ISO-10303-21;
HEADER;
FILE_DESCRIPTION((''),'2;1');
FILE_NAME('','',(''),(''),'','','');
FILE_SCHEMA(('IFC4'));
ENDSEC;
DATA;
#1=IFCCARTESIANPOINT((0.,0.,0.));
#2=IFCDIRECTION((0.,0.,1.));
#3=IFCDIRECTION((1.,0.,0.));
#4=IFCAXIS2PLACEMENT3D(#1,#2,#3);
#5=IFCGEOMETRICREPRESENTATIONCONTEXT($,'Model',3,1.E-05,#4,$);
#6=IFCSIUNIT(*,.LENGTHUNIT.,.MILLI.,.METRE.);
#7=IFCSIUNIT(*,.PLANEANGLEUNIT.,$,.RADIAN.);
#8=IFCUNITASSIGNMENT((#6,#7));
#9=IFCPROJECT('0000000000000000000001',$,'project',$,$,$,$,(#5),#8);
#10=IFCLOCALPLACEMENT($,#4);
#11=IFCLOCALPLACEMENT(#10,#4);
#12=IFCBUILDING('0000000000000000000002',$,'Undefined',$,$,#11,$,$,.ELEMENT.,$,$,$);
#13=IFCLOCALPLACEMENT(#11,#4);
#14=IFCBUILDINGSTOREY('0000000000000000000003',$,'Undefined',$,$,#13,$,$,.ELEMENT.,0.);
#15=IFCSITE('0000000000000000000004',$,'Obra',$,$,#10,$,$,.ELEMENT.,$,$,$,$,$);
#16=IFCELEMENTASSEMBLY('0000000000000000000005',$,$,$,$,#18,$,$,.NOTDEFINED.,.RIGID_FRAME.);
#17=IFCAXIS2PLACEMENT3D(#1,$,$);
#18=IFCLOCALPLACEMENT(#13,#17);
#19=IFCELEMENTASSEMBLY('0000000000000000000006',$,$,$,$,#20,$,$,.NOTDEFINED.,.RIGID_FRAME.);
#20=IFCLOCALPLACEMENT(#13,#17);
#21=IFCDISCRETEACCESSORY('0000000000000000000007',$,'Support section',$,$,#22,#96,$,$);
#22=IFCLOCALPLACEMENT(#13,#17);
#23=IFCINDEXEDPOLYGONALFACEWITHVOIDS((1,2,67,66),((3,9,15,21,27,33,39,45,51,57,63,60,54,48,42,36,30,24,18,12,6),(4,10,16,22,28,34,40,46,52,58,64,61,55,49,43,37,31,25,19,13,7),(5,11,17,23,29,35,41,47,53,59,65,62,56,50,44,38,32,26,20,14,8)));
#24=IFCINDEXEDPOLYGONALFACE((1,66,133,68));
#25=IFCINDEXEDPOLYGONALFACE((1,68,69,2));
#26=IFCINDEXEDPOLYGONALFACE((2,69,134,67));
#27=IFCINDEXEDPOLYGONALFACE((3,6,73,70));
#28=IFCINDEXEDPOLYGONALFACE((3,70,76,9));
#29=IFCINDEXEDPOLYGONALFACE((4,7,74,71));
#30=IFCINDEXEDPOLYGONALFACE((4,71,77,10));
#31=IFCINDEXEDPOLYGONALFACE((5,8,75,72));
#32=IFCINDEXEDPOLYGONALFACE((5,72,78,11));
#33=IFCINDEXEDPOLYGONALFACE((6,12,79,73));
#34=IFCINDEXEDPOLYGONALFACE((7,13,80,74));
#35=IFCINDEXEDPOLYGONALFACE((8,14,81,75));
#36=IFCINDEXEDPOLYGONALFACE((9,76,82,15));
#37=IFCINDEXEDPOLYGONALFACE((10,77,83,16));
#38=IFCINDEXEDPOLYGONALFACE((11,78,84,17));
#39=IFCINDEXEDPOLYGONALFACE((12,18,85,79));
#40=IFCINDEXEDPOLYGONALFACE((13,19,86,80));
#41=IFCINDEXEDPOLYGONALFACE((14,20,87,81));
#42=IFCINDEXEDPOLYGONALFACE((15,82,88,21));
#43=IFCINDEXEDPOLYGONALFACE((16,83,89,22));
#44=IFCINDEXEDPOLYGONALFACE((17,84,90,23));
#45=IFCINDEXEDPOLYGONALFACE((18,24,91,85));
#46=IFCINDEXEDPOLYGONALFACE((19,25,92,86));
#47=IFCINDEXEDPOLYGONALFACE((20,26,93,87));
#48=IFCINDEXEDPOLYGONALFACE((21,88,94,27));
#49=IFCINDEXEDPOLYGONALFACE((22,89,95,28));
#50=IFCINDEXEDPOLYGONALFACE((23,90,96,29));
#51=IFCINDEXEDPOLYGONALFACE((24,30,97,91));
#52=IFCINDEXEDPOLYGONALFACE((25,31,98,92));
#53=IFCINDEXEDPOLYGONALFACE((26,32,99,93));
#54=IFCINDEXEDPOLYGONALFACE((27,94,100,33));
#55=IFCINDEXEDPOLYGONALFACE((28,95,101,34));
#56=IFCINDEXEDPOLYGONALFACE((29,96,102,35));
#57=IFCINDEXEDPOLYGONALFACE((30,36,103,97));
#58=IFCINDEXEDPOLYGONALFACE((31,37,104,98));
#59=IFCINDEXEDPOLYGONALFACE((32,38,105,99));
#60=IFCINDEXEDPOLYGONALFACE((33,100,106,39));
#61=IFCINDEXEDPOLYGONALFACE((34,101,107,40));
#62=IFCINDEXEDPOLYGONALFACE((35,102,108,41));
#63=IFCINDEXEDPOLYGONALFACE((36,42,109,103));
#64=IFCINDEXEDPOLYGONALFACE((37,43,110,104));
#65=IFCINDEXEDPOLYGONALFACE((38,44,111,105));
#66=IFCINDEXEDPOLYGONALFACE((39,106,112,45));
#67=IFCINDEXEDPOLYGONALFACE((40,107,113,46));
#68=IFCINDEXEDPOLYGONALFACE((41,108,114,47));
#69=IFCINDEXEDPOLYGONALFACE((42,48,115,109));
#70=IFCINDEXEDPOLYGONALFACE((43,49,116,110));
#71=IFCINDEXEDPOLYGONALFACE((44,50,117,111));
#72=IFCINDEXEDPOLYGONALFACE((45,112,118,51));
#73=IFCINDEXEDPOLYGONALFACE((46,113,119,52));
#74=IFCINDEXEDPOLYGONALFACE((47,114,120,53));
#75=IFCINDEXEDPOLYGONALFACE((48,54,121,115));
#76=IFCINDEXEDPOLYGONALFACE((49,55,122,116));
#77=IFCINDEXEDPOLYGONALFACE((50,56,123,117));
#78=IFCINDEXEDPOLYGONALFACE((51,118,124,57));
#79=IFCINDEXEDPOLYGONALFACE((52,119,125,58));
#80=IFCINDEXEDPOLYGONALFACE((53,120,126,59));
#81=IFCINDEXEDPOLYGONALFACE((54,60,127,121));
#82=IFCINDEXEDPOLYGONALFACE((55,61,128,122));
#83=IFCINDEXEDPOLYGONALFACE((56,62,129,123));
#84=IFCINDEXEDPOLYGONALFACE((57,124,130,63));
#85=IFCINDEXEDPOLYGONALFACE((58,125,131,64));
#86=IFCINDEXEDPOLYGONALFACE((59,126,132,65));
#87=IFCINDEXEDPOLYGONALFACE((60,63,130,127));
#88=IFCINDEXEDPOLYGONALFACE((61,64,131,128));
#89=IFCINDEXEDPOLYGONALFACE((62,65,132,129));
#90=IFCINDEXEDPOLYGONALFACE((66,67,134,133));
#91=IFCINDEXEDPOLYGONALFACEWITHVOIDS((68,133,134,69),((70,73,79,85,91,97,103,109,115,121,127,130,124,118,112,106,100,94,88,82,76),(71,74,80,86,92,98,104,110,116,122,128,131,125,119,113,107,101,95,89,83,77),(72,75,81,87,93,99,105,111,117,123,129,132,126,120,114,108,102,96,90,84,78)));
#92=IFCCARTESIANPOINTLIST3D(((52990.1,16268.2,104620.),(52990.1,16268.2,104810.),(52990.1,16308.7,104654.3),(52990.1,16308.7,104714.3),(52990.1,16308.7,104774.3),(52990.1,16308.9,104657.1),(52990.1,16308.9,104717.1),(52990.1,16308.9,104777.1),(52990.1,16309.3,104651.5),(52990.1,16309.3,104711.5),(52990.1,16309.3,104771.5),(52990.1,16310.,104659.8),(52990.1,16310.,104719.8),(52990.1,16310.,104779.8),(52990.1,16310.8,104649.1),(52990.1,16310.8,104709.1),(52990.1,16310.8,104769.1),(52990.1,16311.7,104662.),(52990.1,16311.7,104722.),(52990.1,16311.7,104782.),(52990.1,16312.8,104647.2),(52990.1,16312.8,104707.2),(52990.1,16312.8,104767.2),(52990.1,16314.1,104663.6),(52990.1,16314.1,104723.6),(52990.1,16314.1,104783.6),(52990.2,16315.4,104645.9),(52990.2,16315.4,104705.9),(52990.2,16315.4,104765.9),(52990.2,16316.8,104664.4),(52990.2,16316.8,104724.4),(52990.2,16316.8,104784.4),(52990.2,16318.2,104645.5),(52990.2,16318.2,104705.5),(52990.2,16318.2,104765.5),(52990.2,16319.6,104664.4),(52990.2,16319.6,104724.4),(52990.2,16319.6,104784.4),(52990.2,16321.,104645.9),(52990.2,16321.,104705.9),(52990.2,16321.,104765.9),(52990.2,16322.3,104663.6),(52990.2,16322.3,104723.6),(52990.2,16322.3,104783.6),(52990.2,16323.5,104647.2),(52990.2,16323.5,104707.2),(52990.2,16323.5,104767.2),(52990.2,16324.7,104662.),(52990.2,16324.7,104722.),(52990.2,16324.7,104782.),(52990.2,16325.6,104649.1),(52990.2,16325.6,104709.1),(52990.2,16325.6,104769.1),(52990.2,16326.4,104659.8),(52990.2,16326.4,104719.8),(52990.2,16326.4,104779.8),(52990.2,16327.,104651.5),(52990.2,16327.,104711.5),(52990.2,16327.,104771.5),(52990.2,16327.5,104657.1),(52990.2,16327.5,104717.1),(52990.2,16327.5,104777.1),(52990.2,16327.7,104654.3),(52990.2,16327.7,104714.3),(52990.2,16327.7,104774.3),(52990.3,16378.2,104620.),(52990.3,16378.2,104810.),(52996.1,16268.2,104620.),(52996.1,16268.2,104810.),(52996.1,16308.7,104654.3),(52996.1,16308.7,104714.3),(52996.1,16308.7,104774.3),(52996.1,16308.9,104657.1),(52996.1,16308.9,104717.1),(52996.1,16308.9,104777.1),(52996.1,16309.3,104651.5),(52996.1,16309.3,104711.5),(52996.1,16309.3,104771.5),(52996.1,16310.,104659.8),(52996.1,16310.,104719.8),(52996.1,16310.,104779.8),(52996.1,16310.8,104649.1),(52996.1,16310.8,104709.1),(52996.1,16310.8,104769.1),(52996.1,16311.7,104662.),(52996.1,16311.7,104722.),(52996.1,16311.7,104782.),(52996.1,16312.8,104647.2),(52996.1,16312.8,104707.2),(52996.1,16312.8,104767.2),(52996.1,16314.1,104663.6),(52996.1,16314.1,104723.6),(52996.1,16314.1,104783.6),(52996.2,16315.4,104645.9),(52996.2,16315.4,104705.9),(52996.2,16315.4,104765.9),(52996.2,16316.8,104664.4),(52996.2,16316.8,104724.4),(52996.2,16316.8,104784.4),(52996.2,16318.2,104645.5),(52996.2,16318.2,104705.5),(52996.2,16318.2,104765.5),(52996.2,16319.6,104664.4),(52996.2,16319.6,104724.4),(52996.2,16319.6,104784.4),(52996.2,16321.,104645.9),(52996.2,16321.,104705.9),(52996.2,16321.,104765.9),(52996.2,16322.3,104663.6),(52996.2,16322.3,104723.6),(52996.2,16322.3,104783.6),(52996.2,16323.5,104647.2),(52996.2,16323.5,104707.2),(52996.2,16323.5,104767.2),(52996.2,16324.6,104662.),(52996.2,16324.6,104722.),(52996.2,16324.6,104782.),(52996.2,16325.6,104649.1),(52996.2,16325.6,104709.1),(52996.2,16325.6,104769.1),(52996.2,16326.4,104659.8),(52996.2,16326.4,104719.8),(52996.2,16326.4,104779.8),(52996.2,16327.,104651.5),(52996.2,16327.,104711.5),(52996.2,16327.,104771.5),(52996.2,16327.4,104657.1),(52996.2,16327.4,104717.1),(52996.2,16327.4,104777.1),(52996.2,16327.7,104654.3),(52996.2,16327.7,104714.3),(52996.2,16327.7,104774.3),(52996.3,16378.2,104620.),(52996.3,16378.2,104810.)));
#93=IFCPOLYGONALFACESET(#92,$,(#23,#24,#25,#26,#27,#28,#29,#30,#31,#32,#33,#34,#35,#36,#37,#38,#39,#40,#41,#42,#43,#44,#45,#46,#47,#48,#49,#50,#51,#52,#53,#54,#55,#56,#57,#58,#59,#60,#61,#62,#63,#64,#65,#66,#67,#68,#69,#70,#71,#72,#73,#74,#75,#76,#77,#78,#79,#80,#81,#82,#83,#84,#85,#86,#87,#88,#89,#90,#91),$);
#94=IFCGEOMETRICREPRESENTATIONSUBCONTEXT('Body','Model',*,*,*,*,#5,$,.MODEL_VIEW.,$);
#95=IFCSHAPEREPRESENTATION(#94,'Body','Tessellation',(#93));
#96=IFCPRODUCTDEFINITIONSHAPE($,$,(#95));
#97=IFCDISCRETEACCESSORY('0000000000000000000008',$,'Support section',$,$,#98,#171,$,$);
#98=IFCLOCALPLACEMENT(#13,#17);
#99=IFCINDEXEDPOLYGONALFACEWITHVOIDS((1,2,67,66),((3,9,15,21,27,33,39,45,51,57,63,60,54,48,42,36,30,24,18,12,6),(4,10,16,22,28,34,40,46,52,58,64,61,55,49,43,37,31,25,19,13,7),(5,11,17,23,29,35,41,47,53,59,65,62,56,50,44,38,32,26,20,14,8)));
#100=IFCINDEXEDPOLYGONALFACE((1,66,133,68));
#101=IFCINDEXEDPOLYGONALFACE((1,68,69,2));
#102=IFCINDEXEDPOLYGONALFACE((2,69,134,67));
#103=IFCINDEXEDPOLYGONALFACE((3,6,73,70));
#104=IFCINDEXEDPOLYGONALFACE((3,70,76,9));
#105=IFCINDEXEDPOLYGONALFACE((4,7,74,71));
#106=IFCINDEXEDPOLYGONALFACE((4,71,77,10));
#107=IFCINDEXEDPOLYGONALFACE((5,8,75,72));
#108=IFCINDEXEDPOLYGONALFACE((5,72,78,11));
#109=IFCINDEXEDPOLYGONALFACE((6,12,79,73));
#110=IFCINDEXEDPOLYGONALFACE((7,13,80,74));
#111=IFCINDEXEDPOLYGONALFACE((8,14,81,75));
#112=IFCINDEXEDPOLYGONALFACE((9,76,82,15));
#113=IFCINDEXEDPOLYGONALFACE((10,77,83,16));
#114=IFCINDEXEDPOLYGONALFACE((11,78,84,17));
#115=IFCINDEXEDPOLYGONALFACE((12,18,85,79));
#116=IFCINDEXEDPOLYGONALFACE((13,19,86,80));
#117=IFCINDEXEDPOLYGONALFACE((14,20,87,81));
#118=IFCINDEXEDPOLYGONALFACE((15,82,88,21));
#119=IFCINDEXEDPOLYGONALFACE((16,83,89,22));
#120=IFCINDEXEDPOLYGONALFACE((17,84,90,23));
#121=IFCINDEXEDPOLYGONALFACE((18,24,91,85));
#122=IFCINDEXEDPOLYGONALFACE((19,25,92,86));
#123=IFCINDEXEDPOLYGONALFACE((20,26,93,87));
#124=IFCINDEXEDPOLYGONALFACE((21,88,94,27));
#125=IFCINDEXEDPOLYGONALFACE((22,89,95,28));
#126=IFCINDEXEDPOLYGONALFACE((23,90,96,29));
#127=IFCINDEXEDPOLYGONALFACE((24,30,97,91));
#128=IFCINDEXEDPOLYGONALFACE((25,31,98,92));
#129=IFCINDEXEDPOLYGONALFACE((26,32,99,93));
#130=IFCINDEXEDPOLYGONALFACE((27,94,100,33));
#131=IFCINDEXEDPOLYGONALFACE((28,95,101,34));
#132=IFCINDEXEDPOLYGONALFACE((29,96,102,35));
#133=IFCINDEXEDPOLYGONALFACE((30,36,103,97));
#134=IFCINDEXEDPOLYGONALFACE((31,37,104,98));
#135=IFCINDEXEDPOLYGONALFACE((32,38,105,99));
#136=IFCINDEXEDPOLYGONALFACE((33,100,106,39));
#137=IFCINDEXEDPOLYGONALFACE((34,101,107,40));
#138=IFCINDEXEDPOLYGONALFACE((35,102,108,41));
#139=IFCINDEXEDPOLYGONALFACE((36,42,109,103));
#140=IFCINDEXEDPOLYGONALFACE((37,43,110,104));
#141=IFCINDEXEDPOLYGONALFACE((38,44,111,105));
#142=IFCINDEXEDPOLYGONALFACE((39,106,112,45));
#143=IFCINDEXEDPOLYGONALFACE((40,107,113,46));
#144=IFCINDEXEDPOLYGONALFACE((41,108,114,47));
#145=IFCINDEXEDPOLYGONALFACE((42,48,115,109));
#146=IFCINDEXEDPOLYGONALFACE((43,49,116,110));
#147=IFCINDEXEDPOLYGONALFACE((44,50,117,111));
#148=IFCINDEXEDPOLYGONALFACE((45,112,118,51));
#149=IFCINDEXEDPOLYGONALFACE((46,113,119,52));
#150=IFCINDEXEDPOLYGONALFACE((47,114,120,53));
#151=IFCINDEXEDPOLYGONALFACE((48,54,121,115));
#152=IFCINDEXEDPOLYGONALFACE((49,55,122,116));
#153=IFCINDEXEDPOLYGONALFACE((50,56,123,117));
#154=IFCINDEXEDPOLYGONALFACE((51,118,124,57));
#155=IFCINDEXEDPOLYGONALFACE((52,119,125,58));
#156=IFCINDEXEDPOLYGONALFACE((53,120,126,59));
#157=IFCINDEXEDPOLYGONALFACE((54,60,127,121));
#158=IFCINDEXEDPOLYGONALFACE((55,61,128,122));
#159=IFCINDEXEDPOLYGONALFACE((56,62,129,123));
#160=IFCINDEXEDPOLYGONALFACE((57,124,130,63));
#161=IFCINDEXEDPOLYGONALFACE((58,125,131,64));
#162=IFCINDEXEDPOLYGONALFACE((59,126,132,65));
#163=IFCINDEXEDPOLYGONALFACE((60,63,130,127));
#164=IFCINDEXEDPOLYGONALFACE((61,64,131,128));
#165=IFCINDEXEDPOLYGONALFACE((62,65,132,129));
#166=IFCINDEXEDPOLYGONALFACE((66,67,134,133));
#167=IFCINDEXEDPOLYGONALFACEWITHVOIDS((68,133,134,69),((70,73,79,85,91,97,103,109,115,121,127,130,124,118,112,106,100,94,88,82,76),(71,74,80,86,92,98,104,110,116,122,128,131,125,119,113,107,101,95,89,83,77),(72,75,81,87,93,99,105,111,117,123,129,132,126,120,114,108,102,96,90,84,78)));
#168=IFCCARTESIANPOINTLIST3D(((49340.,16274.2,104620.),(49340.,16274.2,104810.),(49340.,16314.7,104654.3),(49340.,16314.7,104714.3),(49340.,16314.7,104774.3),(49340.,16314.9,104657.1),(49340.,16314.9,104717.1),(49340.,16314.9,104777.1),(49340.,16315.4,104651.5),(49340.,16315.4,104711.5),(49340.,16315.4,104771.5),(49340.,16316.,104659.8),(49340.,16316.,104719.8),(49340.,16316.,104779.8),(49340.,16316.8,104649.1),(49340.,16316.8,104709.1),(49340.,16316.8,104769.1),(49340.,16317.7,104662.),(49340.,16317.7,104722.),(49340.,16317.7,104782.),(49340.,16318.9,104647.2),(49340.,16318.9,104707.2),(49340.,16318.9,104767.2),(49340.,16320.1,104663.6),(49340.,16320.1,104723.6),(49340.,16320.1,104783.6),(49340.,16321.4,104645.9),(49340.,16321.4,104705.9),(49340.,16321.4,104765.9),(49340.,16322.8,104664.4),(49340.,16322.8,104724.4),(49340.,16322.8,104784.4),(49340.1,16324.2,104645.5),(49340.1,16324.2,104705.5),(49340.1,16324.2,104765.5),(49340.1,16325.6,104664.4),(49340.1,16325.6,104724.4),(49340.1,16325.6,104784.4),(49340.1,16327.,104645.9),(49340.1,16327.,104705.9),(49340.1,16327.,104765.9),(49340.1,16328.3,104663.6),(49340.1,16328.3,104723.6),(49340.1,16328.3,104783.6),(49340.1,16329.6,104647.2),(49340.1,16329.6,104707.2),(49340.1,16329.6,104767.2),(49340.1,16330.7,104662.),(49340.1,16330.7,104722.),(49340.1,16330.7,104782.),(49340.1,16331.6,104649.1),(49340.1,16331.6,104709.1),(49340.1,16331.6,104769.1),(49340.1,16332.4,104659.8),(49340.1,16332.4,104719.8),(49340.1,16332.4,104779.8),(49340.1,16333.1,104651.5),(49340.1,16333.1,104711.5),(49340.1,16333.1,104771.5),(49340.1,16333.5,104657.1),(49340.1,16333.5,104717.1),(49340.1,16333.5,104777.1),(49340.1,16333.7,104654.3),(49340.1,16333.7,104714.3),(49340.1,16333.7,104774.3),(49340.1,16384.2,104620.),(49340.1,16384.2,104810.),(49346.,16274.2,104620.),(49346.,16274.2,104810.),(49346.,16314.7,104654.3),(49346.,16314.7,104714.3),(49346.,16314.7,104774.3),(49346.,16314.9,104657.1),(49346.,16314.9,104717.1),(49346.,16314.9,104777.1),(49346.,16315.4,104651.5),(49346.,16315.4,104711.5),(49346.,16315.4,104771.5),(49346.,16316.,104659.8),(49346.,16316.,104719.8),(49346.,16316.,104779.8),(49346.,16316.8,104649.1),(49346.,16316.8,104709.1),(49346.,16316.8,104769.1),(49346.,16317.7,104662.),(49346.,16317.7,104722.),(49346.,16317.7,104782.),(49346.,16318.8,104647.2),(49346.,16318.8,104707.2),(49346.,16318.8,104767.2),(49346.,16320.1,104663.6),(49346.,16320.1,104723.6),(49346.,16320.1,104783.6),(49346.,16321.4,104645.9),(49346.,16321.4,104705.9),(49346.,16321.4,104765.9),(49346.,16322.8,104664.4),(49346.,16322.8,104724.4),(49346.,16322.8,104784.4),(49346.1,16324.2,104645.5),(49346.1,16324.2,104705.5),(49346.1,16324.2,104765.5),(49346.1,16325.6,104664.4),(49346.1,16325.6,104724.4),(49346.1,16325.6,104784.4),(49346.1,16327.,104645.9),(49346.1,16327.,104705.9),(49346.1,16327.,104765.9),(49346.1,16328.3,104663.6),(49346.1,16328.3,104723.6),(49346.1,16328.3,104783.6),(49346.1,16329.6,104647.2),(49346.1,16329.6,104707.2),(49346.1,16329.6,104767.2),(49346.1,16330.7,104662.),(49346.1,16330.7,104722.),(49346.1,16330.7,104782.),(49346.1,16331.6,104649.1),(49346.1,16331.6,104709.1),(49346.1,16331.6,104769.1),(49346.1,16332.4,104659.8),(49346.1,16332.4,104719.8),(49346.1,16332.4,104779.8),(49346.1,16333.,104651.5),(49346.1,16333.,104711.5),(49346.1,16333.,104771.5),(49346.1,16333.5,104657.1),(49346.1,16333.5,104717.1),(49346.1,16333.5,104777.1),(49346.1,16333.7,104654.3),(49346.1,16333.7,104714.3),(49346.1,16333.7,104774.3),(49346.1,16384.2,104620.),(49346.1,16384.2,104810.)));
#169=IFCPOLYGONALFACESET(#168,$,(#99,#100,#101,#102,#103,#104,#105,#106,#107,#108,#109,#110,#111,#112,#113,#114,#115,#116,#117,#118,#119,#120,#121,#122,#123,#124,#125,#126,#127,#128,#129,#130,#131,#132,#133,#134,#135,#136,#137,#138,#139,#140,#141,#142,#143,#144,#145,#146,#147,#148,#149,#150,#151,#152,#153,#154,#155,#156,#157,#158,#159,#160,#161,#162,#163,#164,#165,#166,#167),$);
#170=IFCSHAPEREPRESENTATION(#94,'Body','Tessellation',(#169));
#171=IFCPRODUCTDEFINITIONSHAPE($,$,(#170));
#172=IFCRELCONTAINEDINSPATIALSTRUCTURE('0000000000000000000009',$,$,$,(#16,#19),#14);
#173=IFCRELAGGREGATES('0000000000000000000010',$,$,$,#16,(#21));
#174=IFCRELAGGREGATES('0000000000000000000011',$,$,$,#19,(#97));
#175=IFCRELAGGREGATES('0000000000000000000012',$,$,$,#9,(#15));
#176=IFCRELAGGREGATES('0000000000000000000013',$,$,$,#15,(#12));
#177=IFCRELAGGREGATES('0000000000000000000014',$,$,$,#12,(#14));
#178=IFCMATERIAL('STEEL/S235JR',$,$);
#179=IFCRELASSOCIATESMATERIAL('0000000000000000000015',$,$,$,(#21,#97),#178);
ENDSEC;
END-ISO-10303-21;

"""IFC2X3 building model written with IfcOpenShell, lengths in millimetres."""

from ifc_helpers import new_model, si_unit, frame, origin_with_axes, origin_2d_with_axis, place, context, subcontext, project, spatial, rectangle, circle, extrude, source, transform, mapped, material, element, aggregate, save


model = new_model("IFC2X3")

# Units and contexts
model_context = context("Model", 3, precision=1e-05, world=origin_with_axes())
body_context = subcontext(model_context, "Body", "Model", "MODEL_VIEW")
ifc_project = project(units=[si_unit("LENGTHUNIT", "METRE", prefix="MILLI"), si_unit("PLANEANGLEUNIT", "RADIAN")], contexts=[model_context])

# Site, building, storey
site_placement = place(None, origin_with_axes())
site = spatial("IfcSite", under=ifc_project, at=site_placement, Name="Obra", CompositionType="ELEMENT")
building_placement = place(site_placement, origin_with_axes())
building = spatial("IfcBuilding", under=site, at=building_placement, Name="Undefined", CompositionType="ELEMENT")
storey_placement = place(building_placement, origin_with_axes())
storey = spatial("IfcBuildingStorey", under=building, at=storey_placement, Name="Undefined", CompositionType="ELEMENT", Elevation=0.0)

# Element assemblies
assembly_1_placement = place(storey_placement, origin_with_axes())
assembly_1 = element("IfcElementAssembly", 1, at=assembly_1_placement, inside=storey, AssemblyPlace="NOTDEFINED", PredefinedType="RIGID_FRAME")
ifc_material = material(Name="STEEL/S235JR")
assembly_2_placement = place(storey_placement, origin_with_axes())
assembly_2 = element("IfcElementAssembly", 2, at=assembly_2_placement, inside=storey, AssemblyPlace="NOTDEFINED", PredefinedType="RIGID_FRAME")

# Shared definitions
shared_shape_1 = source(origin_with_axes(), body_context, "Body", "SweptSolid", [
    extrude(circle(Radius=9.5, at=origin_2d_with_axis()), frame((0.0, -9.2, 0.0), z_axis=(0.0, 1.0, 0.0), x_axis=(1.0, 0.0, 0.0)), (0.0, 0.0, 1.0), 6.2),
])

# Discrete accessories, openings
discrete_accessory_1_placement = place(assembly_1_placement, frame((52993.2, 16323.2, 104620.0), z_axis=(0.0, 0.0, 1.0), x_axis=(0.001649, 0.999999, 0.0)))
discrete_accessory_1 = element("IfcDiscreteAccessory", 3, at=discrete_accessory_1_placement, material=ifc_material, Name="Support section", context=body_context, shape_type="SweptSolid", body=[
    extrude(rectangle(XDim=6.0, YDim=110.0, at=origin_2d_with_axis()), frame((0.0, 0.0, 190.0), z_axis=(0.0, 0.0, -1.0), x_axis=(0.0, 1.0, 0.0)), (0.0, 0.0, 1.0), 190.0),
])
opening_1_placement = place(assembly_1_placement, frame((52999.3, 16368.2, 104835.0), z_axis=(-0.001649, -0.999999, 0.0), x_axis=(0.0, 0.0, -1.0)))
element("IfcOpeningElement", 4, at=opening_1_placement, cuts=discrete_accessory_1, ObjectType="Opening", context=body_context, shape_type="MappedRepresentation", body=[
    mapped(shared_shape_1, transform((60.0, 0.0, 50.0))),
    mapped(shared_shape_1, transform((120.0, 0.0, 50.0))),
    mapped(shared_shape_1, transform((180.0, 0.0, 50.0))),
])
aggregate(assembly_1, [discrete_accessory_1])
discrete_accessory_2_placement = place(assembly_2_placement, frame((49343.1, 16329.2, 104620.0), z_axis=(0.0, 0.0, 1.0), x_axis=(0.001649, 0.999999, 0.0)))
discrete_accessory_2 = element("IfcDiscreteAccessory", 5, at=discrete_accessory_2_placement, material=ifc_material, Name="Support section", context=body_context, shape_type="SweptSolid", body=[
    extrude(rectangle(XDim=6.0, YDim=110.0, at=origin_2d_with_axis()), frame((0.0, 0.0, 190.0), z_axis=(0.0, 0.0, -1.0), x_axis=(0.0, 1.0, 0.0)), (0.0, 0.0, 1.0), 190.0),
])
opening_2_placement = place(assembly_2_placement, frame((49349.2, 16374.2, 104835.0), z_axis=(-0.001649, -0.999999, 0.0), x_axis=(0.0, 0.0, -1.0)))
element("IfcOpeningElement", 6, at=opening_2_placement, cuts=discrete_accessory_2, ObjectType="Opening", context=body_context, shape_type="MappedRepresentation", body=[
    mapped(shared_shape_1, transform((60.0, 0.0, 50.0))),
    mapped(shared_shape_1, transform((120.0, 0.0, 50.0))),
    mapped(shared_shape_1, transform((180.0, 0.0, 50.0))),
])
aggregate(assembly_2, [discrete_accessory_2])

save(model, "model.ifc")
